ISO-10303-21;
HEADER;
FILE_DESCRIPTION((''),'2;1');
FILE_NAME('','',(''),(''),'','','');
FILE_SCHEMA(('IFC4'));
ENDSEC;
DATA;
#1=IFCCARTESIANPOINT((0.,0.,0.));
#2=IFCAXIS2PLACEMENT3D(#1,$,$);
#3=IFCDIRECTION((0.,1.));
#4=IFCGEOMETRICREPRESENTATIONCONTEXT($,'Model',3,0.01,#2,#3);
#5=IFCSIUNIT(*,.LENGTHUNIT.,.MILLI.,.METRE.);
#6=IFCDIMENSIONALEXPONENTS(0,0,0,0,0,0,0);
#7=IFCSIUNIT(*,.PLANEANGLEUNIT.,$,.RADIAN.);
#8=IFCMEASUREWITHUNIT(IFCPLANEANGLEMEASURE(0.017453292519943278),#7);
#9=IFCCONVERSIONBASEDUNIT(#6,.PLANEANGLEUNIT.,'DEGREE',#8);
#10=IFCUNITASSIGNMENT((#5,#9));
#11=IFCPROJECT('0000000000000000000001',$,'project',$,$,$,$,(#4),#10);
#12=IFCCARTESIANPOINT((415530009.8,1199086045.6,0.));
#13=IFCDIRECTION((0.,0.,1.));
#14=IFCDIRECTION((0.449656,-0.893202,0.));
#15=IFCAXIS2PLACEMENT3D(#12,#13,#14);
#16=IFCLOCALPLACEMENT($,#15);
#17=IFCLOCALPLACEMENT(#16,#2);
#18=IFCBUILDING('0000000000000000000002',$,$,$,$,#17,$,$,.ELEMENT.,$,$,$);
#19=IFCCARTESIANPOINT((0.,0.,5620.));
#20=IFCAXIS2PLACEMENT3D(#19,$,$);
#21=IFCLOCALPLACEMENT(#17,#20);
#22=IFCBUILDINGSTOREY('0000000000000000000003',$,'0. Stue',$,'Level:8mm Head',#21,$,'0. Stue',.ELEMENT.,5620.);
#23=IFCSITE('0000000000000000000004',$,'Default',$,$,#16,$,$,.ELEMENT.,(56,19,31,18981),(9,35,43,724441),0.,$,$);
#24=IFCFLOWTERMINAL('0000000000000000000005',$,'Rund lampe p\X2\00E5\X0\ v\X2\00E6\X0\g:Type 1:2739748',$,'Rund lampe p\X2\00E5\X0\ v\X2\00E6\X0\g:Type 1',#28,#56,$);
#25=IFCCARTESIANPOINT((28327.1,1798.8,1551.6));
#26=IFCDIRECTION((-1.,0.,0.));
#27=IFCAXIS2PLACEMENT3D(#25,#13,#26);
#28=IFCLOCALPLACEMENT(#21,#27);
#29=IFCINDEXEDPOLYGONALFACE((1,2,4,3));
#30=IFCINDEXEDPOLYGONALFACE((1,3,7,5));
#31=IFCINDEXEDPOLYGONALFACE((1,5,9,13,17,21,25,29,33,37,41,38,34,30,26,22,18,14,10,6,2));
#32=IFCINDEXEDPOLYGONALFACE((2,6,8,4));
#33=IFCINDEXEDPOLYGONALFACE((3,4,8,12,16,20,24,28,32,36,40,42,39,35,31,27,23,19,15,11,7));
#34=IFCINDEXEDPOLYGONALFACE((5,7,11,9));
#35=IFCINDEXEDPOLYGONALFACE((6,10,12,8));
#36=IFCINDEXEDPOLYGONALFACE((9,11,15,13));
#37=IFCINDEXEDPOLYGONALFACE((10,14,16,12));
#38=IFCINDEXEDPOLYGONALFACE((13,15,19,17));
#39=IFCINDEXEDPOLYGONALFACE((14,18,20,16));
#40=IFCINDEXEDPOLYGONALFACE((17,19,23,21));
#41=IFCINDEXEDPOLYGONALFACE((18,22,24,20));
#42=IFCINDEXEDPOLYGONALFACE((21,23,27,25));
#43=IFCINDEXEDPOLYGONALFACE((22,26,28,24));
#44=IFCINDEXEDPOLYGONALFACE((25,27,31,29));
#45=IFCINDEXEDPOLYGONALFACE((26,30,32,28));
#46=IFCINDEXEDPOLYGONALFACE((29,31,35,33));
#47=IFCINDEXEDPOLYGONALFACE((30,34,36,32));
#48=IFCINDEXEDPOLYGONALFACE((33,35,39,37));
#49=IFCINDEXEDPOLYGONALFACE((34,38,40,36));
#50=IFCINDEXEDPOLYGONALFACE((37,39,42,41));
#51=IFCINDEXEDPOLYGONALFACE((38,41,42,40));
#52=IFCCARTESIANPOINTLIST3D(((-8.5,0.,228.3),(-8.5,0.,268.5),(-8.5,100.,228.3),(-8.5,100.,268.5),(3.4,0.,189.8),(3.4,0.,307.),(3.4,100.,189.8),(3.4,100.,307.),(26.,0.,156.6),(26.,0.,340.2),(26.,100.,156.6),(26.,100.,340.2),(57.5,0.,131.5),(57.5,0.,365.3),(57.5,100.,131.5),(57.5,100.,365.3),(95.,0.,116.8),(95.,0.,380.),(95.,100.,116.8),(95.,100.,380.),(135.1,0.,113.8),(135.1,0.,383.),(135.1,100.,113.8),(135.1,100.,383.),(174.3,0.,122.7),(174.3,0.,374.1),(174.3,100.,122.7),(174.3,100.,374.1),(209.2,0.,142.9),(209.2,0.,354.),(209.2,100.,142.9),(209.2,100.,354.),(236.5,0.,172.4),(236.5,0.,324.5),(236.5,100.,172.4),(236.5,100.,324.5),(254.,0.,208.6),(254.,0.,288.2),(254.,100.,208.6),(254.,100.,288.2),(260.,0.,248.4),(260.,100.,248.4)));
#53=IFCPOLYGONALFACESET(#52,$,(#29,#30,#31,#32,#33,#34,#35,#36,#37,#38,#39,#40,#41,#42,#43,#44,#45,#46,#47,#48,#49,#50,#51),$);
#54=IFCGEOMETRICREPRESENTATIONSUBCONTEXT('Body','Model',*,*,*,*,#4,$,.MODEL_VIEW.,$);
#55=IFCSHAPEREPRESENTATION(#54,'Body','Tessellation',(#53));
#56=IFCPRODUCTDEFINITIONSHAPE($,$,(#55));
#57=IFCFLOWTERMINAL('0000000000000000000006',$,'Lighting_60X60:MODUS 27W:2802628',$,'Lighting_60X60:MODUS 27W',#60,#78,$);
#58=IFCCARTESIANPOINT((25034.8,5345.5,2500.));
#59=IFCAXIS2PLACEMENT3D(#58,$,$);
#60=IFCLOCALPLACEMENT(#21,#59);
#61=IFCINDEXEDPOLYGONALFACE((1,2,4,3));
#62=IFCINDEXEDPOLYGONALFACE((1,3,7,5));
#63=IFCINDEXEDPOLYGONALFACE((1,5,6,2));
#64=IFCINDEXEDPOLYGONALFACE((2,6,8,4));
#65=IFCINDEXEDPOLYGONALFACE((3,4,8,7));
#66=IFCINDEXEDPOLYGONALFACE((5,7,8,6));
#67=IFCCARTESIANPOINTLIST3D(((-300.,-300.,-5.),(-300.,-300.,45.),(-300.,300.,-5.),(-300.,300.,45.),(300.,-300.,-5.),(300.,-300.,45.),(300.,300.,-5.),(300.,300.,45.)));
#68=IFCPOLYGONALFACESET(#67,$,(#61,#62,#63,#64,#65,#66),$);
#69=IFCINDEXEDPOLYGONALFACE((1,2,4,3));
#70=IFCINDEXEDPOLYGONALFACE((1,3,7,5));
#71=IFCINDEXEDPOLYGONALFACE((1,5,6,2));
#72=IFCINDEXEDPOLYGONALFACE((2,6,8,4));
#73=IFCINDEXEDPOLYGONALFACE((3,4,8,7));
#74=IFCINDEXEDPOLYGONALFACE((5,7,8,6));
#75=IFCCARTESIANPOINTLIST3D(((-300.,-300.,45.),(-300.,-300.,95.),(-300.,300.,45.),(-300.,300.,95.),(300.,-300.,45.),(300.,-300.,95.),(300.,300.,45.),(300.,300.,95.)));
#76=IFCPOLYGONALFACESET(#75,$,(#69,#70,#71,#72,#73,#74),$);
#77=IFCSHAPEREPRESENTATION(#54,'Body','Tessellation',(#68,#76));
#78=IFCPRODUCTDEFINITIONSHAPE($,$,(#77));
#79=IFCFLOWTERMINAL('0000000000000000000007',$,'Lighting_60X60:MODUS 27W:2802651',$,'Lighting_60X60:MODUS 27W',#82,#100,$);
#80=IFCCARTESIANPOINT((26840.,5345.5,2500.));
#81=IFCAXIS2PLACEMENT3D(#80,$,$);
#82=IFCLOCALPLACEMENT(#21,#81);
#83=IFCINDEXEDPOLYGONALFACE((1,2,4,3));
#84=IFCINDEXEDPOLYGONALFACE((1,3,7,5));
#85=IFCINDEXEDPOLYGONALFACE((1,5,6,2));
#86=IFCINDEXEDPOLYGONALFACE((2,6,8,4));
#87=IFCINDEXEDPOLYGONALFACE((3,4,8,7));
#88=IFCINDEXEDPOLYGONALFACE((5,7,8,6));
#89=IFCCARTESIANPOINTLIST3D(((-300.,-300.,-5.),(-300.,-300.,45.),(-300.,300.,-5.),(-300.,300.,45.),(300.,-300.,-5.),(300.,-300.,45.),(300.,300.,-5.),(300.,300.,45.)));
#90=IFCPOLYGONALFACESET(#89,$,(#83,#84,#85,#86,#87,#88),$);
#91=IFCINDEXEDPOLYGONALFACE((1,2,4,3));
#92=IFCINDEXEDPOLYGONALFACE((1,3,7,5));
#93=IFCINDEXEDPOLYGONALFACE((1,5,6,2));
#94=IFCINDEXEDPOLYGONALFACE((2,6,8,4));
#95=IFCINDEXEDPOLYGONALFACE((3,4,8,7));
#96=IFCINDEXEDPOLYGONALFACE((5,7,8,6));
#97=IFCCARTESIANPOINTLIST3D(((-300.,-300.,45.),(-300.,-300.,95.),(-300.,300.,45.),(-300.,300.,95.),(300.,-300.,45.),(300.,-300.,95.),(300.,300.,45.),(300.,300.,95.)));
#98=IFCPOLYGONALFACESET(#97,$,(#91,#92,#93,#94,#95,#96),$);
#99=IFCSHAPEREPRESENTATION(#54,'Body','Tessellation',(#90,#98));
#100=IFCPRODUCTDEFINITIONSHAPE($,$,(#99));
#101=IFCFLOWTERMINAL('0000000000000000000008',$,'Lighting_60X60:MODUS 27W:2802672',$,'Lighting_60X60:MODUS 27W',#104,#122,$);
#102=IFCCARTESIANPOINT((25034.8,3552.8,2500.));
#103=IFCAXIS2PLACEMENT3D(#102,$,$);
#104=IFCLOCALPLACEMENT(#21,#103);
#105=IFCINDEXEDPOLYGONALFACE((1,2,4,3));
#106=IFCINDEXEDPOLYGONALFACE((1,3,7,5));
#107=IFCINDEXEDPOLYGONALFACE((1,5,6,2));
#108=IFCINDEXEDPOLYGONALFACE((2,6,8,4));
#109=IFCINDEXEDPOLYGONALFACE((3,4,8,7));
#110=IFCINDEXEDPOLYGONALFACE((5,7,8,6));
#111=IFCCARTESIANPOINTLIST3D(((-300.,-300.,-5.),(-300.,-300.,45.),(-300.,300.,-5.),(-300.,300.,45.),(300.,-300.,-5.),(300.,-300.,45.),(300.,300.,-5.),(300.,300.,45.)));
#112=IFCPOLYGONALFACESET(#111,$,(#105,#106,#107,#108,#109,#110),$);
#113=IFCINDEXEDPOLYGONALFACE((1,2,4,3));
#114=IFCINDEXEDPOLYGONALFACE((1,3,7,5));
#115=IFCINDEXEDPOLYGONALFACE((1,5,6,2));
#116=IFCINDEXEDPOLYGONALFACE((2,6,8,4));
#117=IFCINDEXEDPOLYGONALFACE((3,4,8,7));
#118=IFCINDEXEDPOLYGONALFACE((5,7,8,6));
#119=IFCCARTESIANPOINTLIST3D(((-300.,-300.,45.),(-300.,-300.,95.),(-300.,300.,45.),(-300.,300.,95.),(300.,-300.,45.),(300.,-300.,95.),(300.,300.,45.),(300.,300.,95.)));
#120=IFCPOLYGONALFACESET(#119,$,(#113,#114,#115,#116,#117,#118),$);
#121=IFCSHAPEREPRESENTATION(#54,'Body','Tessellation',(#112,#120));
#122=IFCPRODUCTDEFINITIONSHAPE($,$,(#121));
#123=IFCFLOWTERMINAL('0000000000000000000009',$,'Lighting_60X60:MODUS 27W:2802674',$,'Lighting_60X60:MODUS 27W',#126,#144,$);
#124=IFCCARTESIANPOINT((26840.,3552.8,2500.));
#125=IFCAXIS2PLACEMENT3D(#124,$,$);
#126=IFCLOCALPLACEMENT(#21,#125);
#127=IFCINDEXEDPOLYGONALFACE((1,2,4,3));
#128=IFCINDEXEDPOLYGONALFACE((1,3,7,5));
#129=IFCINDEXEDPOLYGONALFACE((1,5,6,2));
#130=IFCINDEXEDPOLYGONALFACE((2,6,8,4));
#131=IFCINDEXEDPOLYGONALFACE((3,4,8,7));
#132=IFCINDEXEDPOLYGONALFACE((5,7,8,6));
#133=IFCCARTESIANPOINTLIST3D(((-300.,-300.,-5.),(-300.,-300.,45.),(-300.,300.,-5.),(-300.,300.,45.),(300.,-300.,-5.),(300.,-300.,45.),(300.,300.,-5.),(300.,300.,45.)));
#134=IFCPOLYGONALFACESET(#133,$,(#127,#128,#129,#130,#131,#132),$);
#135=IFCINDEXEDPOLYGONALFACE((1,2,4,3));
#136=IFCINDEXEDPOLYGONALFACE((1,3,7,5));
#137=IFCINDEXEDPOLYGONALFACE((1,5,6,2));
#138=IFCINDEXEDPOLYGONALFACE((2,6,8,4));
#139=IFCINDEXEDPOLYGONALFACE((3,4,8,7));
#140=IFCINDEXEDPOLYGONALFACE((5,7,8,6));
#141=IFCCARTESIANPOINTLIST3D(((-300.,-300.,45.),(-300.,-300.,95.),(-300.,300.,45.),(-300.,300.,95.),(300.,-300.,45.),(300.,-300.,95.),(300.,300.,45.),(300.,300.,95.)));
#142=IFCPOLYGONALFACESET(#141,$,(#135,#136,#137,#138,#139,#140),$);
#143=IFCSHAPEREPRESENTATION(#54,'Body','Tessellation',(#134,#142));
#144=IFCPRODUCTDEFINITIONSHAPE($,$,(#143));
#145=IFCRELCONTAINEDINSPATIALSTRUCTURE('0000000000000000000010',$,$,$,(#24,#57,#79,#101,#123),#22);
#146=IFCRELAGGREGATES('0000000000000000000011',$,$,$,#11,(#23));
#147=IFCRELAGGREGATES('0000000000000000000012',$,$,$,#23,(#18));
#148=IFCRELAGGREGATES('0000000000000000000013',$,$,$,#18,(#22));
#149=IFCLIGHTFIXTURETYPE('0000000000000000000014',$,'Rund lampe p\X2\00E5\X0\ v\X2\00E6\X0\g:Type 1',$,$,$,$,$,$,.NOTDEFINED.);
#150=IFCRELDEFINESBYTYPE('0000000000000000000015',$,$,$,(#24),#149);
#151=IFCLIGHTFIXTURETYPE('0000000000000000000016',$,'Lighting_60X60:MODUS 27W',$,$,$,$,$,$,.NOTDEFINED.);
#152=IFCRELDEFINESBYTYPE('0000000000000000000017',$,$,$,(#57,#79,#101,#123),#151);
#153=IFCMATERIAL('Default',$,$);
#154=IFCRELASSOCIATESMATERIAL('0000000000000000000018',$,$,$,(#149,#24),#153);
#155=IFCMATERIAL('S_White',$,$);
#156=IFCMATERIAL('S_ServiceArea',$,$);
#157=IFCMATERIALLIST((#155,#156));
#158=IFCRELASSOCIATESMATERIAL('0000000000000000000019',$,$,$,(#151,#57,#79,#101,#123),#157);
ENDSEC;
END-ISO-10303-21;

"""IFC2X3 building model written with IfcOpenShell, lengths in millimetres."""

from ifc_helpers import new_model, entity, si_unit, converted_unit, direction, frame, frame_2d, origin, origin_2d_with_axis, place, context, subcontext, project, spatial, rectangle, circle, extrude, source, transform, mapped, material, material_list, type_object, type_shapes, element, save


model = new_model("IFC2X3")

# Units and contexts
model_context = context("Model", 3, precision=0.01, world=origin(), true_north=direction((0.0, 1.0)))
body_context = subcontext(model_context, "Body", "Model", "MODEL_VIEW")
ifc_project = project(units=[si_unit("LENGTHUNIT", "METRE", prefix="MILLI"), converted_unit("PLANEANGLEUNIT", "DEGREE", entity("IfcPlaneAngleMeasure", 0.017453292519943278), si_unit("PLANEANGLEUNIT", "RADIAN"), dimensions=[0, 0, 0, 0, 0, 0, 0])], contexts=[model_context])

# Site, building, storey
site_placement = place(None, frame((415530009.8, 1199086045.6, 0.0), z_axis=(0.0, 0.0, 1.0), x_axis=(0.449656, -0.893202, 0.0)))
site = spatial("IfcSite", under=ifc_project, at=site_placement, Name="Default", CompositionType="ELEMENT", RefLatitude=(56, 19, 31, 18981), RefLongitude=(9, 35, 43, 724441), RefElevation=0.0)
building_placement = place(site_placement, origin())
building = spatial("IfcBuilding", under=site, at=building_placement, CompositionType="ELEMENT")
storey_placement = place(building_placement, frame((0.0, 0.0, 5620.0)))
storey = spatial("IfcBuildingStorey", under=building, at=storey_placement, Name="0. Stue", ObjectType="Level:8mm Head", LongName="0. Stue", CompositionType="ELEMENT", Elevation=5620.0)

# Flow terminals
ifc_material_1 = material(Name="S_White")
ifc_material_2 = material(Name="Default")
light_fixture_type_1 = type_object("IfcLightFixtureType", Name="Rund lampe på væg:Type 1", PredefinedType="NOTDEFINED", material=ifc_material_2)
shared_shape_1 = source(origin(), body_context, "Body", "SweptSolid", [
    extrude(circle(Radius=135.0, at=frame_2d((0.0, 0.0), x_axis=(1.0, 0.0))), frame((125.0, 0.0, 248.4), z_axis=(0.0, 1.0, 0.0), x_axis=(1.0, 0.0, 0.0)), (0.0, 0.0, 1.0), 100.0),
])
type_shapes(light_fixture_type_1, [shared_shape_1])
flow_terminal_1_placement = place(storey_placement, frame((28327.1, 1798.8, 1551.6), z_axis=(0.0, 0.0, 1.0), x_axis=(-1.0, 0.0, 0.0)))
element("IfcFlowTerminal", 1, at=flow_terminal_1_placement, inside=storey, type_object=light_fixture_type_1, material=ifc_material_2, Name="Rund lampe på væg:Type 1:2739748", ObjectType="Rund lampe på væg:Type 1", context=body_context, shape_type="MappedRepresentation", body=[
    mapped(shared_shape_1, transform((0.0, 0.0, 0.0), scale=1.0)),
])
ifc_material_3 = material(Name="S_ServiceArea")
ifc_material_list_1 = material_list([ifc_material_1, ifc_material_3])
light_fixture_type_2 = type_object("IfcLightFixtureType", Name="Lighting_60X60:MODUS 27W", PredefinedType="NOTDEFINED", material=ifc_material_list_1)
shared_shape_2 = source(origin(), body_context, "Body", "SweptSolid", [
    extrude(rectangle(XDim=600.0, YDim=600.0, at=origin_2d_with_axis()), frame((0.0, 0.0, -5.0), z_axis=(0.0, 0.0, 1.0), x_axis=(-1.0, 0.0, 0.0)), (0.0, 0.0, 1.0), 50.0),
    extrude(rectangle(XDim=600.0, YDim=600.0, at=frame_2d((0.0, 0.0), x_axis=(1.0, 0.0))), frame((0.0, 0.0, 45.0), z_axis=(0.0, 0.0, 1.0), x_axis=(-1.0, 0.0, 0.0)), (0.0, 0.0, 1.0), 50.0),
])
type_shapes(light_fixture_type_2, [shared_shape_2])
for number, where, name in (
    (2, (25034.8, 5345.5, 2500.0), "Lighting_60X60:MODUS 27W:2802628"),
    (3, (26840.0, 5345.5, 2500.0), "Lighting_60X60:MODUS 27W:2802651"),
    (4, (25034.8, 3552.8, 2500.0), "Lighting_60X60:MODUS 27W:2802672"),
    (5, (26840.0, 3552.8, 2500.0), "Lighting_60X60:MODUS 27W:2802674"),
):
    element("IfcFlowTerminal", number, at=place(storey_placement, frame(where)), inside=storey, type_object=light_fixture_type_2, material=ifc_material_list_1, Name=name, ObjectType="Lighting_60X60:MODUS 27W", context=body_context, shape_type="MappedRepresentation", body=[
        mapped(shared_shape_2, transform((0.0, 0.0, 0.0), scale=1.0)),
    ])

save(model, "model.ifc")
